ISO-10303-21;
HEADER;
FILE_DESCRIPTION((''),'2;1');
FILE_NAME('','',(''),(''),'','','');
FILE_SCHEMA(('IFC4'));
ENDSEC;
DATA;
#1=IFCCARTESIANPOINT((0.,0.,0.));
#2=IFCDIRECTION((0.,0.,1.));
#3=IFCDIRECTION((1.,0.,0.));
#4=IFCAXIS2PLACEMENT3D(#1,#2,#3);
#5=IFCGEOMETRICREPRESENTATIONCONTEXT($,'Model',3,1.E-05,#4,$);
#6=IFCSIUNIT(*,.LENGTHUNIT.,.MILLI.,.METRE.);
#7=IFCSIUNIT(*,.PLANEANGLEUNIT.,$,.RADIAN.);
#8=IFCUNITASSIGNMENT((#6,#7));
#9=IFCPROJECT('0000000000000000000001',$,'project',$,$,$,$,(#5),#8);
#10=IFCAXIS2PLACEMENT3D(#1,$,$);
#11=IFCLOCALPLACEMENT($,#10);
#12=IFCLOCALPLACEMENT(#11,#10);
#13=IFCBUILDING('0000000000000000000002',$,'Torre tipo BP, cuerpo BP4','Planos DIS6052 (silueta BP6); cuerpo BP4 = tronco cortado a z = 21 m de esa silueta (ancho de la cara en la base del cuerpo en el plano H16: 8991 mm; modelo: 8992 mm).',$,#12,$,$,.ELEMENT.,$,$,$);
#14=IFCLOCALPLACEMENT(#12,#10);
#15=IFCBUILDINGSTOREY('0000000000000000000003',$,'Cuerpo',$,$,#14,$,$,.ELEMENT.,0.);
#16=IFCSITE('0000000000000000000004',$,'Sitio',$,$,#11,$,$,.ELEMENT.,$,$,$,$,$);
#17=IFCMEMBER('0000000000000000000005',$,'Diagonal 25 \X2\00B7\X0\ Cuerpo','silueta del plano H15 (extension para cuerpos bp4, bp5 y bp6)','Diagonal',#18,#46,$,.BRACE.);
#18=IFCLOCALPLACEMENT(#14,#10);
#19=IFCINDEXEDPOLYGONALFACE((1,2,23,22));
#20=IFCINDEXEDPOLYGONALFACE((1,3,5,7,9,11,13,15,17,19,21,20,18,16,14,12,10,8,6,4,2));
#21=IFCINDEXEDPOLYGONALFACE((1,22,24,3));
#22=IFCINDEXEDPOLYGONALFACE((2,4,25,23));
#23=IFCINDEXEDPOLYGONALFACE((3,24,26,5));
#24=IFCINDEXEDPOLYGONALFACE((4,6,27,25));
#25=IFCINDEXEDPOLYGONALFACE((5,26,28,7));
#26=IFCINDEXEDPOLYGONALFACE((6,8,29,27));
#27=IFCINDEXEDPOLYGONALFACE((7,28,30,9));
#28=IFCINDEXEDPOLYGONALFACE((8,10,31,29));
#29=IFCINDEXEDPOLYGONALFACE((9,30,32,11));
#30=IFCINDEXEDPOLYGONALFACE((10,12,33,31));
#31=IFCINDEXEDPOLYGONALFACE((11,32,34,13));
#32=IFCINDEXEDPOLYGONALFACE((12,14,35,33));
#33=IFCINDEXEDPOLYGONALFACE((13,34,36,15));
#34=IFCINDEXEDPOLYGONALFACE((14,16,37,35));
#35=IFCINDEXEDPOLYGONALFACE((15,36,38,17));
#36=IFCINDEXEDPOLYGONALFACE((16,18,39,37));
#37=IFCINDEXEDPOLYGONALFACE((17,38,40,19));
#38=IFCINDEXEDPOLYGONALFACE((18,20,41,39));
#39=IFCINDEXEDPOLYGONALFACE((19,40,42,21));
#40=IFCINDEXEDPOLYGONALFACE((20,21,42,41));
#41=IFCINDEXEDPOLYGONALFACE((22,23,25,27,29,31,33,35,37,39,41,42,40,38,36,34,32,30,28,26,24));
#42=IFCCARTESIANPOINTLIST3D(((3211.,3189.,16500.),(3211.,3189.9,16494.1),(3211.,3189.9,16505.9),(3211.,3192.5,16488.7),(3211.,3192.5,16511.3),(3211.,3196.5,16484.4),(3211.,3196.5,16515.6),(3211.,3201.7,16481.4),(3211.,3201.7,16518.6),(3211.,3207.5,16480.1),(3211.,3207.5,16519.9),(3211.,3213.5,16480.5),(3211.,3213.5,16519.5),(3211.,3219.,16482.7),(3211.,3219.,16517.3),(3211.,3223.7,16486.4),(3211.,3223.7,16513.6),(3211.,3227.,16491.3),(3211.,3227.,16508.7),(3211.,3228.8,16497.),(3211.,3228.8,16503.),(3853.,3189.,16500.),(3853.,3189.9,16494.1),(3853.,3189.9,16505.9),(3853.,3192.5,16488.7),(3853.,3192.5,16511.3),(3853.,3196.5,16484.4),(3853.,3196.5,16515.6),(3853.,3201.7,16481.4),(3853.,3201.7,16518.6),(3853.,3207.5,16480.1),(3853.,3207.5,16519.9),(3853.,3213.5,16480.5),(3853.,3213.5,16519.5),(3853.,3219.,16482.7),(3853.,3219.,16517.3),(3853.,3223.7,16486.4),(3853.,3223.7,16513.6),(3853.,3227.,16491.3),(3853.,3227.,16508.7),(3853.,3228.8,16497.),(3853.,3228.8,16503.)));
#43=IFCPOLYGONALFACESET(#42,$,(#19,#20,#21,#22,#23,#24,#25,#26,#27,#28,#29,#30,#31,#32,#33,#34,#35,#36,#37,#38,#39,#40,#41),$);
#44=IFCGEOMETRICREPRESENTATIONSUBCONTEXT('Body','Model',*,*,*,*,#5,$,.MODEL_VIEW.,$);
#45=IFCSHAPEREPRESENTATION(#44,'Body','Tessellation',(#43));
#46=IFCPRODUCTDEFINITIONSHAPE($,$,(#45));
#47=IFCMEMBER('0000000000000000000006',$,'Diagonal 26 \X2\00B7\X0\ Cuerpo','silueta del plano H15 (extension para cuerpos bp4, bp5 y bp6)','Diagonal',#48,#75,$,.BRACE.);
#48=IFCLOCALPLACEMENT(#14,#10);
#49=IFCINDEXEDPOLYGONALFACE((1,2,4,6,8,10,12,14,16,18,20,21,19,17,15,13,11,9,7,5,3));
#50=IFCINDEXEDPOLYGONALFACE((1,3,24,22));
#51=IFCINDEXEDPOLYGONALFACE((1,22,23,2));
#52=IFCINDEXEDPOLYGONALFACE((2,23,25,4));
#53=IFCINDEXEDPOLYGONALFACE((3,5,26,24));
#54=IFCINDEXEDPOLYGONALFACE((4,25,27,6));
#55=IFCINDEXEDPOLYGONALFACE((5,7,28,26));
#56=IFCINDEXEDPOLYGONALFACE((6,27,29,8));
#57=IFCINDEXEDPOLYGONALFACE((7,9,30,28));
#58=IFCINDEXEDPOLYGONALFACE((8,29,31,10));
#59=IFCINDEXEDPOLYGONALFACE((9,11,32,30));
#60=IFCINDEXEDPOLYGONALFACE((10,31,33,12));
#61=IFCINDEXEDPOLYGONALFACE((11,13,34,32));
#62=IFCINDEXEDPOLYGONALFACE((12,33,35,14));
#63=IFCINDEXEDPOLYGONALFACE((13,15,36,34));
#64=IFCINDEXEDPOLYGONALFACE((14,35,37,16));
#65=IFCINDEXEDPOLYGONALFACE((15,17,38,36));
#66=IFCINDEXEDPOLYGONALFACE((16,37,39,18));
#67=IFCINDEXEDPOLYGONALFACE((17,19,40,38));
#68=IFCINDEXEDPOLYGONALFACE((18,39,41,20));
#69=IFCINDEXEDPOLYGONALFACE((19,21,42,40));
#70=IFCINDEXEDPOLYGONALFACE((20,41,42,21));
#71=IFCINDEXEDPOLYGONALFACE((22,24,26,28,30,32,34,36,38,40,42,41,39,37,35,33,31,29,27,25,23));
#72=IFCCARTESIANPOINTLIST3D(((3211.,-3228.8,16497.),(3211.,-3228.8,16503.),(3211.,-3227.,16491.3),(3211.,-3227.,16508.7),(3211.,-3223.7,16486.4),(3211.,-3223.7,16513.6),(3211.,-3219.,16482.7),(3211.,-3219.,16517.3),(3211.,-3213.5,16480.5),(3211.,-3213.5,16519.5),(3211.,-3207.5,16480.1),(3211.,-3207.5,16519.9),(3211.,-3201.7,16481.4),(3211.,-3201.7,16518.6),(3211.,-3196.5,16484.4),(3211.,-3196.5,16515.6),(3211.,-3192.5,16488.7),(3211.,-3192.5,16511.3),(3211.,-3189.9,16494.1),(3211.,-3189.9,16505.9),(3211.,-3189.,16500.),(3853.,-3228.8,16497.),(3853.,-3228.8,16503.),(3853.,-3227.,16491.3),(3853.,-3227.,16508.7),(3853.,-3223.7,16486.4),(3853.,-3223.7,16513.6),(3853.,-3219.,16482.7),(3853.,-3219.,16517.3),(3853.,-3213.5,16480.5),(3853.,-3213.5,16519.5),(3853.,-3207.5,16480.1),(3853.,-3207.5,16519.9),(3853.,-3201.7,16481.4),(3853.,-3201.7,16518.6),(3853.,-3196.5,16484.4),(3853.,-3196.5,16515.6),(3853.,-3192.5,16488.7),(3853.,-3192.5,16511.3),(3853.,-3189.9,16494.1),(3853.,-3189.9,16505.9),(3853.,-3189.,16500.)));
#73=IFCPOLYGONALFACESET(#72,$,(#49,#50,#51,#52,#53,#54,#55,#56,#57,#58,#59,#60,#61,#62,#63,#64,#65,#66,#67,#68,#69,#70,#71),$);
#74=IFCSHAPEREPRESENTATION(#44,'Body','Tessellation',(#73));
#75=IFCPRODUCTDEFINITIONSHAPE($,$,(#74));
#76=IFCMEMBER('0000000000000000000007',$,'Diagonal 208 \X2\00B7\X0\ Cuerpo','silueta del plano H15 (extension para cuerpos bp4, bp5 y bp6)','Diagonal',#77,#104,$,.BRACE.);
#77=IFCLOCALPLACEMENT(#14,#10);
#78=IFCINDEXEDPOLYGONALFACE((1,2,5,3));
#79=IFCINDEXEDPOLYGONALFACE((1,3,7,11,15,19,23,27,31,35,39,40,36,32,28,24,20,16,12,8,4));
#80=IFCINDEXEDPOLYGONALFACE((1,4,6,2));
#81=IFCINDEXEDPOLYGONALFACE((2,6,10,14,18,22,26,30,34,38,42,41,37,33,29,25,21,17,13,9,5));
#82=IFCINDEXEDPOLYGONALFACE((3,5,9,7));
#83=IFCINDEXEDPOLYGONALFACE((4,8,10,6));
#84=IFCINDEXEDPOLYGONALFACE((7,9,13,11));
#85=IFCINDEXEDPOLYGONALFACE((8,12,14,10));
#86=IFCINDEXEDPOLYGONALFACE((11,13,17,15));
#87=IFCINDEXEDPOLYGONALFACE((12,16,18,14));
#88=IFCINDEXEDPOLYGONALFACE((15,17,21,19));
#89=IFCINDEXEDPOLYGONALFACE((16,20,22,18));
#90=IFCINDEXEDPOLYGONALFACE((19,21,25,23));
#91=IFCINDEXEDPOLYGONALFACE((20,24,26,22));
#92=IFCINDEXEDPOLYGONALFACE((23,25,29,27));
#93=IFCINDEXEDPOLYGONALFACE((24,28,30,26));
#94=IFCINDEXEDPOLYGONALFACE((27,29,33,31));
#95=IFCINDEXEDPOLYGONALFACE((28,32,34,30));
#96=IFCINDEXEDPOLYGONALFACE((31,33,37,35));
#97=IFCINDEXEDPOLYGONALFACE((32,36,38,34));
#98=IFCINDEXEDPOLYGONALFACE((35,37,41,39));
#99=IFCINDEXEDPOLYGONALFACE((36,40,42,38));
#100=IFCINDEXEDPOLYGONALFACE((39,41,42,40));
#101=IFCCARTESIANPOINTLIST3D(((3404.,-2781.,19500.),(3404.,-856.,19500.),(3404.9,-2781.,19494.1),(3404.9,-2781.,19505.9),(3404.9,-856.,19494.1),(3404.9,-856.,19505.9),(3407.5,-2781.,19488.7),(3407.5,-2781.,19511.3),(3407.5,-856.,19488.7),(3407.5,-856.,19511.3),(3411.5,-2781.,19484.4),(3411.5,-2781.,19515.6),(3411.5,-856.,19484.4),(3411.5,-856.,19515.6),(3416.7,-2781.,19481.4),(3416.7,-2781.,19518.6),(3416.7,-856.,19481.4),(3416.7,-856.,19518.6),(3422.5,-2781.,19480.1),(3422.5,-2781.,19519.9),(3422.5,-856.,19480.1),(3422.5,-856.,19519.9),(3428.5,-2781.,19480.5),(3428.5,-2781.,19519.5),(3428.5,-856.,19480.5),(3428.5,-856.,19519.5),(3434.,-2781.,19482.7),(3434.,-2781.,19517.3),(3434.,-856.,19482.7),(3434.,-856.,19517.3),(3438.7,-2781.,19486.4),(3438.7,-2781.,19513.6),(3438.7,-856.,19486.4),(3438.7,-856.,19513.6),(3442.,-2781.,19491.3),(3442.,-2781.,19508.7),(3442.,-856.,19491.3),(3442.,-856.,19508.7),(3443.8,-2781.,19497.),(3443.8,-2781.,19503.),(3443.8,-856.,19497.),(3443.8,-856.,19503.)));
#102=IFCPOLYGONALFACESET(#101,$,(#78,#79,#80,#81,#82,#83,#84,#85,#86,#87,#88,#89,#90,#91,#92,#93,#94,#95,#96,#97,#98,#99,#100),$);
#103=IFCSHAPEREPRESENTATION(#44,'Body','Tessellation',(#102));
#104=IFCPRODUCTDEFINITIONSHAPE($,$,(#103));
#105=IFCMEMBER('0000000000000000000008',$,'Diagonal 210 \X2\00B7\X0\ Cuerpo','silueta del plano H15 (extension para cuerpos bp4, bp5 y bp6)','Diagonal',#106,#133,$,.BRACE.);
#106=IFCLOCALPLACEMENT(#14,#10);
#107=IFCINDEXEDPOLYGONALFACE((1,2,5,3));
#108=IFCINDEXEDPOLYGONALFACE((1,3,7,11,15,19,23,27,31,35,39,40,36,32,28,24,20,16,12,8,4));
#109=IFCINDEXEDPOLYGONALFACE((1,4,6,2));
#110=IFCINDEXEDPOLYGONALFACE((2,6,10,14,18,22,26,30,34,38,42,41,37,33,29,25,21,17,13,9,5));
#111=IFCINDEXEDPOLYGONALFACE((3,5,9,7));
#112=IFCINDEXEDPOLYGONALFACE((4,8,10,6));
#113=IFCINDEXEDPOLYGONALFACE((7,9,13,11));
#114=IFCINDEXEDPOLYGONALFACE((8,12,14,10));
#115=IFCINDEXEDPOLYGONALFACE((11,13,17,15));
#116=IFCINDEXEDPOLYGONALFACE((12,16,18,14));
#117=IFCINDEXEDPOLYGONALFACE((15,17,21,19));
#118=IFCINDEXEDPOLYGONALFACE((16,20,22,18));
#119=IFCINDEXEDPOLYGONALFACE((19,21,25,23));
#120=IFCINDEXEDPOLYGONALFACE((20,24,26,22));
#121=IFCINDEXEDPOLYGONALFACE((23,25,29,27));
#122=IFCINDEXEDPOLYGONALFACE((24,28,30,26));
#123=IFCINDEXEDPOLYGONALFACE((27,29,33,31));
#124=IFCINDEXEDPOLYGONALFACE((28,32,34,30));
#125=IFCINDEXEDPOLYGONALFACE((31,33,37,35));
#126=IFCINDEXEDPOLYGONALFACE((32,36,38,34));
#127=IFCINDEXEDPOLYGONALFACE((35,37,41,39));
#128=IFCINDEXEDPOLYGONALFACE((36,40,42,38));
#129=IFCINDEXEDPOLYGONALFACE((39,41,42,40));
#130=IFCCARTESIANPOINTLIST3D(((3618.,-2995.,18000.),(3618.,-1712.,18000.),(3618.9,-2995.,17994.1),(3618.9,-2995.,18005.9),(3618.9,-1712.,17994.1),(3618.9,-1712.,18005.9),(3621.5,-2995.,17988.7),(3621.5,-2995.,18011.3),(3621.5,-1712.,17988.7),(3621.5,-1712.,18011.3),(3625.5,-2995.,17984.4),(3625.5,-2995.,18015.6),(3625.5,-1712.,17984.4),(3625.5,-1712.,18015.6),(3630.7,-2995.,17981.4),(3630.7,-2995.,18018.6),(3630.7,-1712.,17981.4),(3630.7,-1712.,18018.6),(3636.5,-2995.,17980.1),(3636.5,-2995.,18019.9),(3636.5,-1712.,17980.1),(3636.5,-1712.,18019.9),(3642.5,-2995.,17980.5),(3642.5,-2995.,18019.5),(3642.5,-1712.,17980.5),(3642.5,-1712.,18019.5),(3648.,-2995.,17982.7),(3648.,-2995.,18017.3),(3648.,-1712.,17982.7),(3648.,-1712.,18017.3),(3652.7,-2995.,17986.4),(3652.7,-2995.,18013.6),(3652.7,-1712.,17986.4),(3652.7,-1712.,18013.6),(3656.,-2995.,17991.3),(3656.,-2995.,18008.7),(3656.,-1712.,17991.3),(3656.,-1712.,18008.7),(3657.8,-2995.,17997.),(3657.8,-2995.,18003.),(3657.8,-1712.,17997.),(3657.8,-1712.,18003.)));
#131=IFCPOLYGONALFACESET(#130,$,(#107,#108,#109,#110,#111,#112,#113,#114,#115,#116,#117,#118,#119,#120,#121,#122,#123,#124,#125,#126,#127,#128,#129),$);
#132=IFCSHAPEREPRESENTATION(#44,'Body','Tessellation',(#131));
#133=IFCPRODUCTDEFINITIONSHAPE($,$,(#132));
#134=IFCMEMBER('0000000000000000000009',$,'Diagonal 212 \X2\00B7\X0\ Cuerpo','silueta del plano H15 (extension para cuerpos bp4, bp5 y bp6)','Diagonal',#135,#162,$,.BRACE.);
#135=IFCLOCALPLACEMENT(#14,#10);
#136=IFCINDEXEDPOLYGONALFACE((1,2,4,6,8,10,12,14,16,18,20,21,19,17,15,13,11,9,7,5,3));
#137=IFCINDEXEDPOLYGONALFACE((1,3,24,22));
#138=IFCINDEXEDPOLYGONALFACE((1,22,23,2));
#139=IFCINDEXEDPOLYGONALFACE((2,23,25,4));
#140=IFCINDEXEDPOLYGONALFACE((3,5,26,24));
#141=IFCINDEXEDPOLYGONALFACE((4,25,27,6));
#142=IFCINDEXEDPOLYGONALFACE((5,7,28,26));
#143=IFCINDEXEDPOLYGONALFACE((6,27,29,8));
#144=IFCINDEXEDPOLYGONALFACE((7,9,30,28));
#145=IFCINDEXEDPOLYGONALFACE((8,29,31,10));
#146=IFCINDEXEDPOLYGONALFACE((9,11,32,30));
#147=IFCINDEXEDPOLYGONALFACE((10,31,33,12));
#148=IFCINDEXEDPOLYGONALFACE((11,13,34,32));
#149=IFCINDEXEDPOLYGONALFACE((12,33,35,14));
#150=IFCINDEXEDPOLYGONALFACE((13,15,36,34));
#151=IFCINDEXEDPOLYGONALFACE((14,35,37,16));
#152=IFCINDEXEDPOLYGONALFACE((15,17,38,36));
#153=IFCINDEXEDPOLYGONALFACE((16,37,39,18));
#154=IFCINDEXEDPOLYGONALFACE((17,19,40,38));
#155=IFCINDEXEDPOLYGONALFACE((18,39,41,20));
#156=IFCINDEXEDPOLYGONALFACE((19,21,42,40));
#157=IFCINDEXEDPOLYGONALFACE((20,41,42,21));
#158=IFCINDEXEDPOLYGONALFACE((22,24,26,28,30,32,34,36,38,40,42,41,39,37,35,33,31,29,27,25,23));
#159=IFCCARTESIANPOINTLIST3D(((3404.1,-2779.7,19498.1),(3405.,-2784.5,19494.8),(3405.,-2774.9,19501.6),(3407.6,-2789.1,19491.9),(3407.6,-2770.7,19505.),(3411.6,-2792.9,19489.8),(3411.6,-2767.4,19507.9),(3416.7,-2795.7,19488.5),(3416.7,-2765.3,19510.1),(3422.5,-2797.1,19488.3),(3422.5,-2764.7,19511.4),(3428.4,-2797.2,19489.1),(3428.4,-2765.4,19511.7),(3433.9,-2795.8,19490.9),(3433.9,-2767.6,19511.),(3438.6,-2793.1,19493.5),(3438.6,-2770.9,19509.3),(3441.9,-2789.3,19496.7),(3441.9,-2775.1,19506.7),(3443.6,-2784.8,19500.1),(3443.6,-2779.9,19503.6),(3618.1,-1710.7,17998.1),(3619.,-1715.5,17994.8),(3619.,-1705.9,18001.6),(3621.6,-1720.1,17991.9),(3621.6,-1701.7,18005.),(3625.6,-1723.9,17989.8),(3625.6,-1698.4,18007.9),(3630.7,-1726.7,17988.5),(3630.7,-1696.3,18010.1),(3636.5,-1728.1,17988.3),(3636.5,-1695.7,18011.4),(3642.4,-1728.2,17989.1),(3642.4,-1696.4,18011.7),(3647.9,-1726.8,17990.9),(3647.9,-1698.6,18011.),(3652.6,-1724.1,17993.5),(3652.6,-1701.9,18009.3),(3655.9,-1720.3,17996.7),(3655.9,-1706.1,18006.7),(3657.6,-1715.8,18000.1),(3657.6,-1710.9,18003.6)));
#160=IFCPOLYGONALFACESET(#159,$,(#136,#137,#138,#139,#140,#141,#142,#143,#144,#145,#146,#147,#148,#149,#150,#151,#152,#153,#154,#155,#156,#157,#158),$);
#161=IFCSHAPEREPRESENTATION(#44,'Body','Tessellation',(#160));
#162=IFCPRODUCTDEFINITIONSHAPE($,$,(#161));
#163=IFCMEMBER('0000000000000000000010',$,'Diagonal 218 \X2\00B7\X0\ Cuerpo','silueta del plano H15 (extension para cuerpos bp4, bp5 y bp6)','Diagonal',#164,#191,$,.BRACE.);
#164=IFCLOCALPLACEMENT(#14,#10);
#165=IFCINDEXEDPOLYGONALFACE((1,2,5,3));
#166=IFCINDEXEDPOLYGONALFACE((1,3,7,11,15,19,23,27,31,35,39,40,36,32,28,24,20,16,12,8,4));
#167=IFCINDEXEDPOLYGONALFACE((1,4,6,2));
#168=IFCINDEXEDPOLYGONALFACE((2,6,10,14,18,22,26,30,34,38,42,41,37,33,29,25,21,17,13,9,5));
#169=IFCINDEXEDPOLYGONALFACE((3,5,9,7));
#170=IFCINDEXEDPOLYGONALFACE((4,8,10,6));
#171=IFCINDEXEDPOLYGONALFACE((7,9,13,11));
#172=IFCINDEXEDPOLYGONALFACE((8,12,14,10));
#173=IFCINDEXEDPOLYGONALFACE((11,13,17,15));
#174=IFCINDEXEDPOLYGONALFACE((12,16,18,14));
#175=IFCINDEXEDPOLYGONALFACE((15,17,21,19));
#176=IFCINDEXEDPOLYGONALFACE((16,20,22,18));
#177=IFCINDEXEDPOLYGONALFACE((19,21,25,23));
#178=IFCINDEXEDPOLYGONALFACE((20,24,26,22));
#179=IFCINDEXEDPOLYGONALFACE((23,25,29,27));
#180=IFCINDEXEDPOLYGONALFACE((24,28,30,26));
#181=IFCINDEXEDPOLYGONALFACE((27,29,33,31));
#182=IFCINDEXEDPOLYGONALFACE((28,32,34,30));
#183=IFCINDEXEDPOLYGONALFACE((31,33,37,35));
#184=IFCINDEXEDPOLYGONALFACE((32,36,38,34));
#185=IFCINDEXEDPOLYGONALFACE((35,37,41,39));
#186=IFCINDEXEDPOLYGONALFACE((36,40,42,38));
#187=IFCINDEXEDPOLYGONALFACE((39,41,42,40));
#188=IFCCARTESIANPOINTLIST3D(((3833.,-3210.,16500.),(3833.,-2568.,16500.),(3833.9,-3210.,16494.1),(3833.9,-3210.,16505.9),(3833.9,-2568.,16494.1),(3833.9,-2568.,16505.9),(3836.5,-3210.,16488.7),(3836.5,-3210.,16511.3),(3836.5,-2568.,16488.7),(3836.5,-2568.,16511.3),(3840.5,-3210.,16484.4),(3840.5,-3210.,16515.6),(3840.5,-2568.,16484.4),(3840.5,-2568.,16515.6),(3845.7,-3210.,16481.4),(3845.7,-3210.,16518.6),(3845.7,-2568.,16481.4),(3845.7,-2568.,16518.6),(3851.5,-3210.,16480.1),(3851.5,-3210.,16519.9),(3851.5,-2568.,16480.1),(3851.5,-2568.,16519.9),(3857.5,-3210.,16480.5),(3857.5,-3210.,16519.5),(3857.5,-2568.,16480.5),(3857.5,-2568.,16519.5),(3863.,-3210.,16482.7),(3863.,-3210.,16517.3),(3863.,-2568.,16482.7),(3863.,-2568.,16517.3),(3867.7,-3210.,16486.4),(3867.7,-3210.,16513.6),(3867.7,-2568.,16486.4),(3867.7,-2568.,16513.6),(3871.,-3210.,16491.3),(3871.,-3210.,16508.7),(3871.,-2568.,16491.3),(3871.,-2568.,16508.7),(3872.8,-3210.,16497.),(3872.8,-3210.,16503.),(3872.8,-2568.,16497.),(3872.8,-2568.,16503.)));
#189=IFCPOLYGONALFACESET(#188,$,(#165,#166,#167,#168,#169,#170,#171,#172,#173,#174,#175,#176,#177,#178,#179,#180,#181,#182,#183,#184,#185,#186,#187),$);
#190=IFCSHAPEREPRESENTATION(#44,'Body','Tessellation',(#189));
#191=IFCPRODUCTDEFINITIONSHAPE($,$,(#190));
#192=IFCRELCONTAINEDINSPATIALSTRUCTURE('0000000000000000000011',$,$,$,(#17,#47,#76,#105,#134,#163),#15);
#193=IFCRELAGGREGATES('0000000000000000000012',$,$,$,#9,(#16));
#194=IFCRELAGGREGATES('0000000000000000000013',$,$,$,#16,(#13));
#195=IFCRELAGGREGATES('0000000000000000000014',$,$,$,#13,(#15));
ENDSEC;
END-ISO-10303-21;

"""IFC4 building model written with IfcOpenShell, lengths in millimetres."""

from ifc_helpers import new_model, si_unit, frame, origin, origin_with_axes, place, context, subcontext, project, spatial, circle, extrude, element, save


model = new_model("IFC4")

# Units and contexts
model_context = context("Model", 3, precision=1e-05, world=origin_with_axes())
body_context = subcontext(model_context, "Body", "Model", "MODEL_VIEW")
ifc_project = project(units=[si_unit("LENGTHUNIT", "METRE", prefix="MILLI"), si_unit("PLANEANGLEUNIT", "RADIAN")], contexts=[model_context])

# Site, building, storey
site_placement = place(None, origin())
site = spatial("IfcSite", under=ifc_project, at=site_placement, Name="Sitio", CompositionType="ELEMENT")
building_placement = place(site_placement, origin())
building = spatial("IfcBuilding", under=site, at=building_placement, Name="Torre tipo BP, cuerpo BP4", Description="Planos DIS6052 (silueta BP6); cuerpo BP4 = tronco cortado a z = 21 m de esa silueta (ancho de la cara en la base del cuerpo en el plano H16: 8991 mm; modelo: 8992 mm).", CompositionType="ELEMENT")
storey_placement = place(building_placement, origin())
storey = spatial("IfcBuildingStorey", under=building, at=storey_placement, Name="Cuerpo", CompositionType="ELEMENT", Elevation=0.0)

# Members
for number, where, z_axis, x_axis, name in (
    (1, (3211.0, 3209.0, 16500.0), (1.0, 0.0, 0.0), (0.0, -1.0, 0.0), "Diagonal 25 · Cuerpo"),
    (2, (3211.0, -3209.0, 16500.0), (1.0, 0.0, 0.0), (0.0, 1.0, 0.0), "Diagonal 26 · Cuerpo"),
):
    element("IfcMember", number, at=place(storey_placement, frame(where, z_axis=z_axis, x_axis=x_axis)), inside=storey, Name=name, Description="silueta del plano H15 (extension para cuerpos bp4, bp5 y bp6)", ObjectType="Diagonal", PredefinedType="BRACE", context=body_context, shape_type="SweptSolid", body=[
        extrude(circle(Radius=20.0), None, (0.0, 0.0, 1.0), 642.0),
    ])
member_1_placement = place(storey_placement, frame((3424.0, -856.0, 19500.0), z_axis=(0.0, -1.0, 0.0), x_axis=(-1.0, 0.0, 0.0)))
element("IfcMember", 3, at=member_1_placement, inside=storey, Name="Diagonal 208 · Cuerpo", Description="silueta del plano H15 (extension para cuerpos bp4, bp5 y bp6)", ObjectType="Diagonal", PredefinedType="BRACE", context=body_context, shape_type="SweptSolid", body=[
    extrude(circle(Radius=20.0), None, (0.0, 0.0, 1.0), 1925.0),
])
member_2_placement = place(storey_placement, frame((3638.0, -1712.0, 18000.0), z_axis=(0.0, -1.0, 0.0), x_axis=(-1.0, 0.0, 0.0)))
element("IfcMember", 4, at=member_2_placement, inside=storey, Name="Diagonal 210 · Cuerpo", Description="silueta del plano H15 (extension para cuerpos bp4, bp5 y bp6)", ObjectType="Diagonal", PredefinedType="BRACE", context=body_context, shape_type="SweptSolid", body=[
    extrude(circle(Radius=20.0), None, (0.0, 0.0, 1.0), 1283.0),
])
member_3_placement = place(storey_placement, frame((3638.0, -1712.0, 18000.0), z_axis=(-0.115405, -0.576487, 0.808915), x_axis=(-0.993318, 0.066977, -0.093981)))
element("IfcMember", 5, at=member_3_placement, inside=storey, Name="Diagonal 212 · Cuerpo", Description="silueta del plano H15 (extension para cuerpos bp4, bp5 y bp6)", ObjectType="Diagonal", PredefinedType="BRACE", context=body_context, shape_type="SweptSolid", body=[
    extrude(circle(Radius=20.0), None, (0.0, 0.0, 1.0), 1854.3),
])
member_4_placement = place(storey_placement, frame((3853.0, -2568.0, 16500.0), z_axis=(0.0, -1.0, 0.0), x_axis=(-1.0, 0.0, 0.0)))
element("IfcMember", 6, at=member_4_placement, inside=storey, Name="Diagonal 218 · Cuerpo", Description="silueta del plano H15 (extension para cuerpos bp4, bp5 y bp6)", ObjectType="Diagonal", PredefinedType="BRACE", context=body_context, shape_type="SweptSolid", body=[
    extrude(circle(Radius=20.0), None, (0.0, 0.0, 1.0), 642.0),
])

save(model, "model.ifc")
